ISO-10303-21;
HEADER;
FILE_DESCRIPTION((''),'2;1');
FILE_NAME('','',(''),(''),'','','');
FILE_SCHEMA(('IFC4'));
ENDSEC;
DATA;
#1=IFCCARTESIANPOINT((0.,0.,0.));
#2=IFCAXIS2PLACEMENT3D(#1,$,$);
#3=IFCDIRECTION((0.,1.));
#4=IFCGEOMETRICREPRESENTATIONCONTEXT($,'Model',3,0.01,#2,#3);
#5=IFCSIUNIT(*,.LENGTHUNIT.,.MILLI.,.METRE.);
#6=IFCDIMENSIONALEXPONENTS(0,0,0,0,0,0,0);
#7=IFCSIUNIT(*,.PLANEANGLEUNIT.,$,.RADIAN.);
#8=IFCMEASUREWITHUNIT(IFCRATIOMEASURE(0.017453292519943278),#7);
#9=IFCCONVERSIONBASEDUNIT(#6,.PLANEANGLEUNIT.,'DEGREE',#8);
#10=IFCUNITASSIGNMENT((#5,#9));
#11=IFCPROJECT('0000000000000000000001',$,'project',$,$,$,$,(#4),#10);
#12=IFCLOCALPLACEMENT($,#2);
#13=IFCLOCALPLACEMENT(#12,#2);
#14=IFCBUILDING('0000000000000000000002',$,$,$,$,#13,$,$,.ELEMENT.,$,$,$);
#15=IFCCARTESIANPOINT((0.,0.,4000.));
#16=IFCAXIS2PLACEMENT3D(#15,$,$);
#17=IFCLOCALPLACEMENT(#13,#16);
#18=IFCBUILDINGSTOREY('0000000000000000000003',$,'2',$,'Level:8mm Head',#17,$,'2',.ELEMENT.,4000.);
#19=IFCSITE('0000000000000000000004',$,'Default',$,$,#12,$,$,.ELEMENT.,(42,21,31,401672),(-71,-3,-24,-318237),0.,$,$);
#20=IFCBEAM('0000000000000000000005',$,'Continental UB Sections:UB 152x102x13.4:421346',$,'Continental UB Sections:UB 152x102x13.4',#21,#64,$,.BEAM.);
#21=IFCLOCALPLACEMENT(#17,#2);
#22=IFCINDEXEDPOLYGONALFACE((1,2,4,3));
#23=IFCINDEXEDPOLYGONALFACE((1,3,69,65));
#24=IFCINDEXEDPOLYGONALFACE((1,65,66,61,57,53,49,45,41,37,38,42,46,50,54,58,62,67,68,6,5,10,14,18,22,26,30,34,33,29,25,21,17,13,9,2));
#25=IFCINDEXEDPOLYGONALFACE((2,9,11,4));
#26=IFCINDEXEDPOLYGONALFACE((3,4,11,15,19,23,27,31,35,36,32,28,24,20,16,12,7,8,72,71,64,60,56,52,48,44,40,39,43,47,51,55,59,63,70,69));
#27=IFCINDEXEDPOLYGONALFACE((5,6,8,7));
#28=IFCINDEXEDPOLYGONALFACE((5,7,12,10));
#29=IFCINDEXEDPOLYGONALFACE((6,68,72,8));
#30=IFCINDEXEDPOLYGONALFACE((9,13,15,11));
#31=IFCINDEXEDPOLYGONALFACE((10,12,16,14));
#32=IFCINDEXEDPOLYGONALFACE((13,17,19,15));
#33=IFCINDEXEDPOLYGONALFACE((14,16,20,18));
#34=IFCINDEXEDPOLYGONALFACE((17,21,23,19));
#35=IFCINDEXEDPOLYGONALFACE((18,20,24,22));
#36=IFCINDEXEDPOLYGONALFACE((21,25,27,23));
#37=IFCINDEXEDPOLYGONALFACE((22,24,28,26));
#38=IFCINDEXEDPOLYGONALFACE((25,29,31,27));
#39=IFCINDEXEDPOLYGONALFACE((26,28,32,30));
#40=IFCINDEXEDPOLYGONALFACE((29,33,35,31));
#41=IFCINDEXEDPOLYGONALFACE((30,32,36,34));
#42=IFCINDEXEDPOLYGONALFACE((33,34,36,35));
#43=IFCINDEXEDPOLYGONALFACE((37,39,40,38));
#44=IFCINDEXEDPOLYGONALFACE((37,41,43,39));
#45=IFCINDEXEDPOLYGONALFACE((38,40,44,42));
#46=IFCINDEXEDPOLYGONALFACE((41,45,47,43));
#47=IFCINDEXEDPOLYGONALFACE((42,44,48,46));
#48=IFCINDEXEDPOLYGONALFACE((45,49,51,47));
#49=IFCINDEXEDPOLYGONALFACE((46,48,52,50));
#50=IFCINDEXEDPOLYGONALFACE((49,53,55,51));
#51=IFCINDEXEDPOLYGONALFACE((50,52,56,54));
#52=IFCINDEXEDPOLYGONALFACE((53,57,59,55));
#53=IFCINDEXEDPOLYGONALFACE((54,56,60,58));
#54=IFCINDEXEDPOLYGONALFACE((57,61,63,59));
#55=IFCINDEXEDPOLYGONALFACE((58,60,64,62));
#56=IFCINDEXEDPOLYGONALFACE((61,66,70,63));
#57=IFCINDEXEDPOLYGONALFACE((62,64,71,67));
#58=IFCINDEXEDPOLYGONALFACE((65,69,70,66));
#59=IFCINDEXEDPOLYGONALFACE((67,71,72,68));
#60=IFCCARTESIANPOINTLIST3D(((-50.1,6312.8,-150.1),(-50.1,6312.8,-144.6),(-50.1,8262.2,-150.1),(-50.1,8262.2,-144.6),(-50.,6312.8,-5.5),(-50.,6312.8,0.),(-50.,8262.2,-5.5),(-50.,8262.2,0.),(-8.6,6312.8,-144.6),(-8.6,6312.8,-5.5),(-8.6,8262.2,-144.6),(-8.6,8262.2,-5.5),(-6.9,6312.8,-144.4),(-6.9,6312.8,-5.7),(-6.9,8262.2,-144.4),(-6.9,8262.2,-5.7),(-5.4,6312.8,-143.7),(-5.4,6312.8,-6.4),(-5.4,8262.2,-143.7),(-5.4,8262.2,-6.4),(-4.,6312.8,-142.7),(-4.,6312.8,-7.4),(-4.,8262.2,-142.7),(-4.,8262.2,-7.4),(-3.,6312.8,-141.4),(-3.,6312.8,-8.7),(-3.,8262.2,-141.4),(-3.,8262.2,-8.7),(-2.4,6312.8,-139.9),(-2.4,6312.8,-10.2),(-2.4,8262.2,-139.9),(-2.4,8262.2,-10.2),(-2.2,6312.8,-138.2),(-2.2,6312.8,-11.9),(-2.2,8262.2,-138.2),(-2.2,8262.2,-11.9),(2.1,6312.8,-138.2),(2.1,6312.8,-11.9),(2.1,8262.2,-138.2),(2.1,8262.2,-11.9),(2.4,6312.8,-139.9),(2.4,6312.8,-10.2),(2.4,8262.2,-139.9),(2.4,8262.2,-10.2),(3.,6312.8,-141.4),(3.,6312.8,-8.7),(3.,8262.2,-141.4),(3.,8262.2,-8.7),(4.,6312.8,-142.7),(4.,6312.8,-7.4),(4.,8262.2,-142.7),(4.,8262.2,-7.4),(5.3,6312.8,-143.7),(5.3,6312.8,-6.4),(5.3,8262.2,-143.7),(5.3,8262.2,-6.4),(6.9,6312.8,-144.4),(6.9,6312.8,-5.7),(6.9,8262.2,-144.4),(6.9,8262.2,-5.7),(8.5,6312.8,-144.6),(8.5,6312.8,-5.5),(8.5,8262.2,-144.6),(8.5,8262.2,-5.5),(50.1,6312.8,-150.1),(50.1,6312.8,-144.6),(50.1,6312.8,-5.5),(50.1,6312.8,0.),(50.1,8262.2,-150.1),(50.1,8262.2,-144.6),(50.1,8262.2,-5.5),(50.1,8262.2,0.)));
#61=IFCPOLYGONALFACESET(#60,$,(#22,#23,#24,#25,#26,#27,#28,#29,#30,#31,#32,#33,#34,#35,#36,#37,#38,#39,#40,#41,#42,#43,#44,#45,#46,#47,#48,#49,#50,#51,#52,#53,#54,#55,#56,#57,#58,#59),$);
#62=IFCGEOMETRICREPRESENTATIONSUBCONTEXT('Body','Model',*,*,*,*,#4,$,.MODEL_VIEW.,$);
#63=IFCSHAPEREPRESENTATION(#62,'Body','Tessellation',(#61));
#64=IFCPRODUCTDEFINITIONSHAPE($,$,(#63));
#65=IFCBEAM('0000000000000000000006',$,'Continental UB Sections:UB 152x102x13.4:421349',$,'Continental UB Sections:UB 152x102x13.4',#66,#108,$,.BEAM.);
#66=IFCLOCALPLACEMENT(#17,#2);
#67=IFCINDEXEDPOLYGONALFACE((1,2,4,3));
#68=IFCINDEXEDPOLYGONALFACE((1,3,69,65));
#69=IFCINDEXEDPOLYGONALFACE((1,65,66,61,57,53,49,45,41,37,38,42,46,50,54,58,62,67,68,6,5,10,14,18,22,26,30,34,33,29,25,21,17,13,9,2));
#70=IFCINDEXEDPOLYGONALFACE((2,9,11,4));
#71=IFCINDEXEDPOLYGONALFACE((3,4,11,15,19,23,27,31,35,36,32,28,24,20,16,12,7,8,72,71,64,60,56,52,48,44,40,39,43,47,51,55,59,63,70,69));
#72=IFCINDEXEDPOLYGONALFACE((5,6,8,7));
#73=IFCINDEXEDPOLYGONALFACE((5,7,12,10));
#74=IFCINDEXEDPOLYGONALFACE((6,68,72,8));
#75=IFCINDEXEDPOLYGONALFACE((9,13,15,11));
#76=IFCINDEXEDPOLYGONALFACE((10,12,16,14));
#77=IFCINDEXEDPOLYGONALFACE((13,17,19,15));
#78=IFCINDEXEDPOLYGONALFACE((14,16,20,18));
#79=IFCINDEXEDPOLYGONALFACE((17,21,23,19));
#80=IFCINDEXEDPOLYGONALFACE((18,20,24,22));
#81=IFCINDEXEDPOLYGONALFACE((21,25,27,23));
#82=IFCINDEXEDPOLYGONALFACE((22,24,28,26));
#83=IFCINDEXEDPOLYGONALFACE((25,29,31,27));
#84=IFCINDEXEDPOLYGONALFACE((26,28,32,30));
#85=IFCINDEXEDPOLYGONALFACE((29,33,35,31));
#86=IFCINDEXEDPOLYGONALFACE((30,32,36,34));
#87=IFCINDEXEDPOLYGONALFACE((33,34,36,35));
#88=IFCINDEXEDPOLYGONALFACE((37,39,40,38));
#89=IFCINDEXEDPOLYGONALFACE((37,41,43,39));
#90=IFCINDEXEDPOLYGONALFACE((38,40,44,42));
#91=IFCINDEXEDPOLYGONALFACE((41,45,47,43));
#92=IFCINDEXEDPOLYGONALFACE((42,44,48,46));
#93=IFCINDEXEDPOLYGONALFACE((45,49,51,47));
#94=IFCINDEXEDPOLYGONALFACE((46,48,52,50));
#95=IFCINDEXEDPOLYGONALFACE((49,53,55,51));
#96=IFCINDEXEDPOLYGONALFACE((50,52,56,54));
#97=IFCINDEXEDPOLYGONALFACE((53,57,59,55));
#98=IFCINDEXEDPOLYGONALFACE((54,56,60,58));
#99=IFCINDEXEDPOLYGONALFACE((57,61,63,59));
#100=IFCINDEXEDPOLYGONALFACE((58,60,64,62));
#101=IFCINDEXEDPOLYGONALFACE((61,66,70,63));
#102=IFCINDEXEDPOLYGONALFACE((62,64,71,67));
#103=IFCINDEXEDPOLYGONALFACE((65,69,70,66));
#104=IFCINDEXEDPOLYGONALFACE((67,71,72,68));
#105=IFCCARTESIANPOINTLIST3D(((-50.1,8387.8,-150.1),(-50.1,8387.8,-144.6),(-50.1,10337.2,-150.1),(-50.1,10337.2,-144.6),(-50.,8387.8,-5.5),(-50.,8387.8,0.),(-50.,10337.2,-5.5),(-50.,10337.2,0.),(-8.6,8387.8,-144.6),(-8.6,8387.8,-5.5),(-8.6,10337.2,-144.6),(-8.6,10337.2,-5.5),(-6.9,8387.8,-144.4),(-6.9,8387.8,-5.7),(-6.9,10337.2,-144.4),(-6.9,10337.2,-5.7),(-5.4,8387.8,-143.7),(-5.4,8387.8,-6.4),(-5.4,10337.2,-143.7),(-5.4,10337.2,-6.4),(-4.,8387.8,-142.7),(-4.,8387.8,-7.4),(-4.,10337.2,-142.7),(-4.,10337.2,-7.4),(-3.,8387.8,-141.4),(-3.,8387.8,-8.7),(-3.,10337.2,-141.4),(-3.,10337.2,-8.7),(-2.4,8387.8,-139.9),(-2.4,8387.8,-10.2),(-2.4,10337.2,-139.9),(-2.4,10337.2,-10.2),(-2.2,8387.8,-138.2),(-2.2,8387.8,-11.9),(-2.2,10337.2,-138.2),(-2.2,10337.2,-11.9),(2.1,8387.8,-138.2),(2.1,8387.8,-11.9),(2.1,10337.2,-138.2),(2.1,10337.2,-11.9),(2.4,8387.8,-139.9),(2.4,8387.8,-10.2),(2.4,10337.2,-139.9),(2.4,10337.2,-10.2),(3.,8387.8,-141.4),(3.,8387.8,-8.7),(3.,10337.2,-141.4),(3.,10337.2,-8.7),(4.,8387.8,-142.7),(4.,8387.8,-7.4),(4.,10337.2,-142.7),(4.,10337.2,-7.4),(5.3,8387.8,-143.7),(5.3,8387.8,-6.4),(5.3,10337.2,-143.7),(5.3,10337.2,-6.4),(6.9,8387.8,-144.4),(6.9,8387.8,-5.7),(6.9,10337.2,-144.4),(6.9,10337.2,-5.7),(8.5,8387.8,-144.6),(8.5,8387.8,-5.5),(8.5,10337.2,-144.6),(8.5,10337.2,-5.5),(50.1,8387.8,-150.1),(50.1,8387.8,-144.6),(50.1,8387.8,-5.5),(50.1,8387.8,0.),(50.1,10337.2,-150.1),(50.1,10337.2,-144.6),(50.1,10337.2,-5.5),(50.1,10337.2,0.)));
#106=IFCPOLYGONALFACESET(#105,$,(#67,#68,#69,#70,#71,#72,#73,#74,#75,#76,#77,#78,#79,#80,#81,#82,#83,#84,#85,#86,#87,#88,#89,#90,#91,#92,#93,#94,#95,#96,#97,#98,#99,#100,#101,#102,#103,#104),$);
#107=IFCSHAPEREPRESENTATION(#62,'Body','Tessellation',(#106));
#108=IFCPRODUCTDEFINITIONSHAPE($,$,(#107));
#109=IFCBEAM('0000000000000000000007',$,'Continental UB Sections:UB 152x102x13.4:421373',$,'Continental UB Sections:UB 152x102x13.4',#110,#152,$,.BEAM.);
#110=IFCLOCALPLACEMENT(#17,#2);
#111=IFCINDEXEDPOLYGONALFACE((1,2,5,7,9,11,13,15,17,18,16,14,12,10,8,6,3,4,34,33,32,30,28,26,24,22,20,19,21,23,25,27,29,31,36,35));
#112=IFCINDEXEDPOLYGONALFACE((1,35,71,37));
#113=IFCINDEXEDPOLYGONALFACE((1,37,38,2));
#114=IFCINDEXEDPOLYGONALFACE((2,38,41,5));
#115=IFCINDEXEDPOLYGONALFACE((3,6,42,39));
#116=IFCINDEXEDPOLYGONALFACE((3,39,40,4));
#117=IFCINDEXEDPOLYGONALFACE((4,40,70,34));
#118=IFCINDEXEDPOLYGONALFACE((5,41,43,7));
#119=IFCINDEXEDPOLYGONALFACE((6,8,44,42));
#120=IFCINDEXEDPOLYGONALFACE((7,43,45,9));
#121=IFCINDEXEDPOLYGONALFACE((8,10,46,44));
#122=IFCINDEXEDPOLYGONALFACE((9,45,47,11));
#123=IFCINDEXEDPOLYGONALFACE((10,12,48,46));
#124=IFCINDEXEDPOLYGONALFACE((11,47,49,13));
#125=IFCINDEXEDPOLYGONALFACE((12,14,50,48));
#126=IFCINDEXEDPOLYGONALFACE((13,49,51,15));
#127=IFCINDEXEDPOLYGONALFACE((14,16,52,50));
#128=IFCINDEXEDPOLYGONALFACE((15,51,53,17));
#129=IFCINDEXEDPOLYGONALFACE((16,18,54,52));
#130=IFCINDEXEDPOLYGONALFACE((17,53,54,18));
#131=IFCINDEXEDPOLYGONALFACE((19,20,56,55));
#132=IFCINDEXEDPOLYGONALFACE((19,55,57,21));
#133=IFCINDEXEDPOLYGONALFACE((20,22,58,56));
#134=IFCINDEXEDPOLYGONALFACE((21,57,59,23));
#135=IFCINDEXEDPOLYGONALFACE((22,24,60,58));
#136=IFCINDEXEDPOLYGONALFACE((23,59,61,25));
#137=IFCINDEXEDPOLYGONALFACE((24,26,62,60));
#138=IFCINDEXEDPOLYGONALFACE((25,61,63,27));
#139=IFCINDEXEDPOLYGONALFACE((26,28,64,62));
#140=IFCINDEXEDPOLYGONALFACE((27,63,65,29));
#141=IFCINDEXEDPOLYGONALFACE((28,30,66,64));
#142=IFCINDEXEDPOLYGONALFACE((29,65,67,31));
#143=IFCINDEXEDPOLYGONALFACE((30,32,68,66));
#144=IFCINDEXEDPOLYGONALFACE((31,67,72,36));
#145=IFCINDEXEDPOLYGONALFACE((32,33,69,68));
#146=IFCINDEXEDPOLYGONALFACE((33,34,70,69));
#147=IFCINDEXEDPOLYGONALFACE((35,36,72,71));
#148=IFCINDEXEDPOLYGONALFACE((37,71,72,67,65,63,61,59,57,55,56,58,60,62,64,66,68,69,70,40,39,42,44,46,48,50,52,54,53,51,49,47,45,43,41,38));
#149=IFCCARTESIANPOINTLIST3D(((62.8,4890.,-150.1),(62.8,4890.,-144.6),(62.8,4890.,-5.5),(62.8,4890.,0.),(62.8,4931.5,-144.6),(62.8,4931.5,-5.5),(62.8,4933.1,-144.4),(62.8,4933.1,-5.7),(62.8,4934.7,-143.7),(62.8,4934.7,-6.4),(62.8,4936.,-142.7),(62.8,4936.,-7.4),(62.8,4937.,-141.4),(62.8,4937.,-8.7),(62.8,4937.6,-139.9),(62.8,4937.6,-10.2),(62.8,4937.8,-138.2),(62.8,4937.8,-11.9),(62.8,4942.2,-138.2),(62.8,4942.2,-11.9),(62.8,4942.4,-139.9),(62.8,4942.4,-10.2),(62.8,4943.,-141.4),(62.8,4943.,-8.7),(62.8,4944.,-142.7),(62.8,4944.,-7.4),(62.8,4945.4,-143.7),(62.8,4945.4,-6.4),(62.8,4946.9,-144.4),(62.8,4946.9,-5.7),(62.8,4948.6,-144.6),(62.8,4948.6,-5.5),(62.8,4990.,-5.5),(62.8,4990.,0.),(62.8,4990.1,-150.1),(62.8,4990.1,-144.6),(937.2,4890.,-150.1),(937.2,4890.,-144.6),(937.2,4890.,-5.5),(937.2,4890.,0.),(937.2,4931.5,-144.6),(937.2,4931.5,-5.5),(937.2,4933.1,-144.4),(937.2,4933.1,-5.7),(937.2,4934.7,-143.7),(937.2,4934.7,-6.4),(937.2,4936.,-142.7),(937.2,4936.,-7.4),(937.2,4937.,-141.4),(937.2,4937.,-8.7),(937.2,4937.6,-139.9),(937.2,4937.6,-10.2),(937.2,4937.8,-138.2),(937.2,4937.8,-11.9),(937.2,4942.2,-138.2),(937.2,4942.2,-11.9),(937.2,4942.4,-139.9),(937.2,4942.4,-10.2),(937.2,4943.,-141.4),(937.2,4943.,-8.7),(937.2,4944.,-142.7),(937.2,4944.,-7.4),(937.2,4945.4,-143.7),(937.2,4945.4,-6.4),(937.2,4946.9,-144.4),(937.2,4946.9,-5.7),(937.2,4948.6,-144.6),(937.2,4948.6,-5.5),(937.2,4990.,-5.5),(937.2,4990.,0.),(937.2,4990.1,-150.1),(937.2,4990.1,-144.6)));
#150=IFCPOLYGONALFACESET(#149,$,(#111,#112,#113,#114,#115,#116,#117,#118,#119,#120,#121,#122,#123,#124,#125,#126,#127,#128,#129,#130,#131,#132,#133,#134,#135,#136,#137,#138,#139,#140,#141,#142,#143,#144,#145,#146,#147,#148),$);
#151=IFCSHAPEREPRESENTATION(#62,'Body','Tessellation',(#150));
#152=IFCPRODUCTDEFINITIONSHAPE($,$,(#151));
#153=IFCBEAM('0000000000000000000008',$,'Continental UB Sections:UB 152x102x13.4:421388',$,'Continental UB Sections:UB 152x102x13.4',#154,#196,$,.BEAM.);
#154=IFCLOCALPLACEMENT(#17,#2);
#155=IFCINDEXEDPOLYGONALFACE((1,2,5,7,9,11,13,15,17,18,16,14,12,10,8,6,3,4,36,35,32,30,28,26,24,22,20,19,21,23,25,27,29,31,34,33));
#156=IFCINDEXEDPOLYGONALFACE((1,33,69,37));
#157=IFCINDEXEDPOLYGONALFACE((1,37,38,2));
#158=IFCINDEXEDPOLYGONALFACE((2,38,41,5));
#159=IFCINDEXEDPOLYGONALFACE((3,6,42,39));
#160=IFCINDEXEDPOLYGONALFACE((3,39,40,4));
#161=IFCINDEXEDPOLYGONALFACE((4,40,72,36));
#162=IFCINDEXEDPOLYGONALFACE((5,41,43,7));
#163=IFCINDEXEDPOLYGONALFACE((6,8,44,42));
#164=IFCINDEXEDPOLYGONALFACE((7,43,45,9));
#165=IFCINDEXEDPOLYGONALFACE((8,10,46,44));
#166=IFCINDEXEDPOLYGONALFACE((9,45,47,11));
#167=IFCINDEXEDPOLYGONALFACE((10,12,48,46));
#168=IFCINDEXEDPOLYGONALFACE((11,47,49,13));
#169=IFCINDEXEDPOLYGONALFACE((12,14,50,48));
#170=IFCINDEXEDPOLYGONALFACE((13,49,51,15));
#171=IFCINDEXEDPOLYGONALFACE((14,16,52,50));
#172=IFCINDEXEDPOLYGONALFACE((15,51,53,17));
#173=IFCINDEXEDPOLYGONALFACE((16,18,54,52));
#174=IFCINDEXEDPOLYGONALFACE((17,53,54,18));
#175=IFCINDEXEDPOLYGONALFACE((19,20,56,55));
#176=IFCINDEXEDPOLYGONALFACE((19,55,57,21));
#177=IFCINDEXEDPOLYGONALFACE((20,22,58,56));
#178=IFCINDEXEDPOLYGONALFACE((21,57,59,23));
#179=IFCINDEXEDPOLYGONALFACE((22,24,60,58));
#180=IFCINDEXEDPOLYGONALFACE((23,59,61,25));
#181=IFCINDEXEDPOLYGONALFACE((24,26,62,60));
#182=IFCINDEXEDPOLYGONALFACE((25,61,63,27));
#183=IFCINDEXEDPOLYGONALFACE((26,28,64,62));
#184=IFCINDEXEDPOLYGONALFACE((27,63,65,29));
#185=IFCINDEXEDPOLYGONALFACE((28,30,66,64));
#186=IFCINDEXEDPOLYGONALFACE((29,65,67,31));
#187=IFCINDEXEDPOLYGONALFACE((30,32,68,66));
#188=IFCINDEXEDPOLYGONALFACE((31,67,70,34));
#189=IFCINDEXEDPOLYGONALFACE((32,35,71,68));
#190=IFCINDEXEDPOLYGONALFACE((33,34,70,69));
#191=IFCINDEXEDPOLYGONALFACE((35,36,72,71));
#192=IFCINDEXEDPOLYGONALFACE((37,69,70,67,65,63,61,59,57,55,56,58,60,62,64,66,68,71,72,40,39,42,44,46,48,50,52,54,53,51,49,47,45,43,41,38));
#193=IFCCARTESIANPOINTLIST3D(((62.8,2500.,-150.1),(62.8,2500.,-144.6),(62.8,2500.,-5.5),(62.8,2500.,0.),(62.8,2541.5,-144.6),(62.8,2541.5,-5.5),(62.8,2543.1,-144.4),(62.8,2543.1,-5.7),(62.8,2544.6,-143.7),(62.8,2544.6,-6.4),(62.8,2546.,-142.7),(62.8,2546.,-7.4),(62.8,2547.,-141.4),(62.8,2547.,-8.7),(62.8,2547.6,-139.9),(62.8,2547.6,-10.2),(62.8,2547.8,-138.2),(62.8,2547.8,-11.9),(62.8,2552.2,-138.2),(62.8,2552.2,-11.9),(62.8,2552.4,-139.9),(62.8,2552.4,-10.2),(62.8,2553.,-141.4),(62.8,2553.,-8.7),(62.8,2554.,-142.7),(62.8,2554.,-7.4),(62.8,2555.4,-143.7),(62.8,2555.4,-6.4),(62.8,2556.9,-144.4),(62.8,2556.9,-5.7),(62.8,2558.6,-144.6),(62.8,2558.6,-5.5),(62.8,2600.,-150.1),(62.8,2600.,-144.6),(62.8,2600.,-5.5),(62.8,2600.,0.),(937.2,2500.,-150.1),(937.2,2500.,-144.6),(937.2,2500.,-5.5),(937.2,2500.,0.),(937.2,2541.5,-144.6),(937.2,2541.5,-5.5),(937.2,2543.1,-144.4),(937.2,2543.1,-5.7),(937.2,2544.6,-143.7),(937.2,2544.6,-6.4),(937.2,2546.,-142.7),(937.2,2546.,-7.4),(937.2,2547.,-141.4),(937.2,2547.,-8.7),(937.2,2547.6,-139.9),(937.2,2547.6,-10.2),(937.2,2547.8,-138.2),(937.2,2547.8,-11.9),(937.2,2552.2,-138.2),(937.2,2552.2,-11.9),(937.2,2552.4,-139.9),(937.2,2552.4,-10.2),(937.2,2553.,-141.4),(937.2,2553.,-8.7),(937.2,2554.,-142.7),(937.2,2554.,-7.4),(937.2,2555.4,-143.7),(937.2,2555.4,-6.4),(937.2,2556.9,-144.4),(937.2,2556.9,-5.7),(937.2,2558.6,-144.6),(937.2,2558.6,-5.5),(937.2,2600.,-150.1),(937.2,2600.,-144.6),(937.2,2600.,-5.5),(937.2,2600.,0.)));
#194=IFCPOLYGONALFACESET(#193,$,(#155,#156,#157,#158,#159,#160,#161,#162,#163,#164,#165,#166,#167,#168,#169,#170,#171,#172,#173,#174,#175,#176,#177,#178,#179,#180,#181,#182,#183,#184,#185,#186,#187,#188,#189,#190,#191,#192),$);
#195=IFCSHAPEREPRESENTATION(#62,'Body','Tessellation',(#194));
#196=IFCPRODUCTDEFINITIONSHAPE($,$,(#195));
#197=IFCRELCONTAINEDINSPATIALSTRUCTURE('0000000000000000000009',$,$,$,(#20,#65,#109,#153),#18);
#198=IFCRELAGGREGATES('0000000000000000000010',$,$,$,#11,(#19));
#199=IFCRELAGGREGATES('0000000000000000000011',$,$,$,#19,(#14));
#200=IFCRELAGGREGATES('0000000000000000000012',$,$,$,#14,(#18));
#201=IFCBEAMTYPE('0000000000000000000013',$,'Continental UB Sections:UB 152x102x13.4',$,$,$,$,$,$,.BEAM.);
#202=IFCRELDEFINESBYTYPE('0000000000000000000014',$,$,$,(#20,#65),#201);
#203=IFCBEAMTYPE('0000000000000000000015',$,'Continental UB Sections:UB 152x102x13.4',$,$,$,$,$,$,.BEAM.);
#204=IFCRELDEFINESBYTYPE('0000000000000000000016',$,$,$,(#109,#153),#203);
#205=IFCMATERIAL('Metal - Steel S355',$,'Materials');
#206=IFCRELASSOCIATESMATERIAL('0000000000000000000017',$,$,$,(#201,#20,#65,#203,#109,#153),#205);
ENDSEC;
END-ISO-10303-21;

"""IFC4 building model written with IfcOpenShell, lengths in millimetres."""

from ifc_helpers import new_model, entity, si_unit, converted_unit, direction, frame, origin, place, context, subcontext, project, spatial, line, arc, indexed_curve, outline, extrude, source, transform, mapped, material, type_object, type_shapes, element, save


model = new_model("IFC4")

# Units and contexts
model_context = context("Model", 3, precision=0.01, world=origin(), true_north=direction((0.0, 1.0)))
body_context = subcontext(model_context, "Body", "Model", "MODEL_VIEW")
ifc_project = project(units=[si_unit("LENGTHUNIT", "METRE", prefix="MILLI"), converted_unit("PLANEANGLEUNIT", "DEGREE", entity("IfcRatioMeasure", 0.017453292519943278), si_unit("PLANEANGLEUNIT", "RADIAN"), dimensions=[0, 0, 0, 0, 0, 0, 0])], contexts=[model_context])

# Site, building, storey
site_placement = place(None, origin())
site = spatial("IfcSite", under=ifc_project, at=site_placement, Name="Default", CompositionType="ELEMENT", RefLatitude=(42, 21, 31, 401672), RefLongitude=(-71, -3, -24, -318237), RefElevation=0.0)
building_placement = place(site_placement, origin())
building = spatial("IfcBuilding", under=site, at=building_placement, CompositionType="ELEMENT")
storey_placement = place(building_placement, frame((0.0, 0.0, 4000.0)))
storey = spatial("IfcBuildingStorey", under=building, at=storey_placement, Name="2", ObjectType="Level:8mm Head", LongName="2", CompositionType="ELEMENT", Elevation=4000.0)

# Beams
ifc_material = material(Name="Metal - Steel S355", Category="Materials")
beam_type_1 = type_object("IfcBeamType", Name="Continental UB Sections:UB 152x102x13.4", PredefinedType="BEAM", material=ifc_material)
shared_shape_1 = source(origin(), body_context, "Body", "SweptSolid", [
    extrude(outline(indexed_curve([(-75.0, -50.1), (-69.6, -50.1), (-69.6, -8.5), (-67.7, -4.0), (-63.2, -2.1), (63.1, -2.1), (67.7, -4.0), (69.5, -8.5), (69.5, -50.1), (75.1, -50.1), (75.1, 50.1), (69.5, 50.1), (69.5, 8.6), (67.7, 4.0), (63.1, 2.2), (-63.2, 2.2), (-67.7, 4.0), (-69.6, 8.6), (-69.6, 50.0), (-75.0, 50.0)], segments=[line(1, 2, 3), arc(3, 4, 5), line(5, 6), arc(6, 7, 8), line(8, 9, 10, 11, 12, 13), arc(13, 14, 15), line(15, 16), arc(16, 17, 18), line(18, 19, 20, 1)], self_intersect=False)), frame((-974.7, 0.0, 0.0), z_axis=(1.0, 0.0, 0.0), x_axis=(0.0, 0.0, -1.0)), (0.0, 0.0, 1.0), 1949.4),
])
type_shapes(beam_type_1, [shared_shape_1])
for number, where, z_axis, x_axis, name in (
    (1, (0.0, 7287.5, -75.1), (0.0, 0.0, 1.0), (0.0, 1.0, 0.0), "Continental UB Sections:UB 152x102x13.4:421346"),
    (2, (0.0, 9362.5, -75.1), (0.0, 0.0, 1.0), (0.0, 1.0, 0.0), "Continental UB Sections:UB 152x102x13.4:421349"),
):
    element("IfcBeam", number, at=place(storey_placement, frame(where, z_axis=z_axis, x_axis=x_axis)), inside=storey, type_object=beam_type_1, material=ifc_material, Name=name, ObjectType="Continental UB Sections:UB 152x102x13.4", PredefinedType="BEAM", context=body_context, shape_type="MappedRepresentation", body=[
        mapped(shared_shape_1, transform((0.0, 0.0, 0.0), scale=1.0)),
    ])
beam_type_2 = type_object("IfcBeamType", Name="Continental UB Sections:UB 152x102x13.4", PredefinedType="BEAM", material=ifc_material)
shared_shape_2 = source(origin(), body_context, "Body", "SweptSolid", [
    extrude(outline(indexed_curve([(-75.0, -50.1), (-69.6, -50.1), (-69.6, -8.5), (-67.7, -4.0), (-63.2, -2.1), (63.1, -2.1), (67.7, -4.0), (69.5, -8.5), (69.5, -50.1), (75.1, -50.1), (75.1, 50.1), (69.5, 50.1), (69.5, 8.6), (67.7, 4.0), (63.1, 2.2), (-63.2, 2.2), (-67.7, 4.0), (-69.6, 8.6), (-69.6, 50.0), (-75.0, 50.0)], segments=[line(1, 2, 3), arc(3, 4, 5), line(5, 6), arc(6, 7, 8), line(8, 9, 10, 11, 12, 13), arc(13, 14, 15), line(15, 16), arc(16, 17, 18), line(18, 19, 20, 1)], self_intersect=False)), frame((-437.2, 0.0, 0.0), z_axis=(1.0, 0.0, 0.0), x_axis=(0.0, 0.0, -1.0)), (0.0, 0.0, 1.0), 874.4),
])
type_shapes(beam_type_2, [shared_shape_2])
beam_1_placement = place(storey_placement, frame((500.0, 4940.0, -75.1)))
element("IfcBeam", 3, at=beam_1_placement, inside=storey, type_object=beam_type_2, material=ifc_material, Name="Continental UB Sections:UB 152x102x13.4:421373", ObjectType="Continental UB Sections:UB 152x102x13.4", PredefinedType="BEAM", context=body_context, shape_type="MappedRepresentation", body=[
    mapped(shared_shape_2, transform((0.0, 0.0, 0.0), scale=1.0)),
])
beam_2_placement = place(storey_placement, frame((500.0, 2550.0, -75.1), z_axis=(0.0, 0.0, 1.0), x_axis=(-1.0, 0.0, 0.0)))
element("IfcBeam", 4, at=beam_2_placement, inside=storey, type_object=beam_type_2, material=ifc_material, Name="Continental UB Sections:UB 152x102x13.4:421388", ObjectType="Continental UB Sections:UB 152x102x13.4", PredefinedType="BEAM", context=body_context, shape_type="MappedRepresentation", body=[
    mapped(shared_shape_2, transform((0.0, 0.0, 0.0), scale=1.0)),
])

save(model, "model.ifc")
